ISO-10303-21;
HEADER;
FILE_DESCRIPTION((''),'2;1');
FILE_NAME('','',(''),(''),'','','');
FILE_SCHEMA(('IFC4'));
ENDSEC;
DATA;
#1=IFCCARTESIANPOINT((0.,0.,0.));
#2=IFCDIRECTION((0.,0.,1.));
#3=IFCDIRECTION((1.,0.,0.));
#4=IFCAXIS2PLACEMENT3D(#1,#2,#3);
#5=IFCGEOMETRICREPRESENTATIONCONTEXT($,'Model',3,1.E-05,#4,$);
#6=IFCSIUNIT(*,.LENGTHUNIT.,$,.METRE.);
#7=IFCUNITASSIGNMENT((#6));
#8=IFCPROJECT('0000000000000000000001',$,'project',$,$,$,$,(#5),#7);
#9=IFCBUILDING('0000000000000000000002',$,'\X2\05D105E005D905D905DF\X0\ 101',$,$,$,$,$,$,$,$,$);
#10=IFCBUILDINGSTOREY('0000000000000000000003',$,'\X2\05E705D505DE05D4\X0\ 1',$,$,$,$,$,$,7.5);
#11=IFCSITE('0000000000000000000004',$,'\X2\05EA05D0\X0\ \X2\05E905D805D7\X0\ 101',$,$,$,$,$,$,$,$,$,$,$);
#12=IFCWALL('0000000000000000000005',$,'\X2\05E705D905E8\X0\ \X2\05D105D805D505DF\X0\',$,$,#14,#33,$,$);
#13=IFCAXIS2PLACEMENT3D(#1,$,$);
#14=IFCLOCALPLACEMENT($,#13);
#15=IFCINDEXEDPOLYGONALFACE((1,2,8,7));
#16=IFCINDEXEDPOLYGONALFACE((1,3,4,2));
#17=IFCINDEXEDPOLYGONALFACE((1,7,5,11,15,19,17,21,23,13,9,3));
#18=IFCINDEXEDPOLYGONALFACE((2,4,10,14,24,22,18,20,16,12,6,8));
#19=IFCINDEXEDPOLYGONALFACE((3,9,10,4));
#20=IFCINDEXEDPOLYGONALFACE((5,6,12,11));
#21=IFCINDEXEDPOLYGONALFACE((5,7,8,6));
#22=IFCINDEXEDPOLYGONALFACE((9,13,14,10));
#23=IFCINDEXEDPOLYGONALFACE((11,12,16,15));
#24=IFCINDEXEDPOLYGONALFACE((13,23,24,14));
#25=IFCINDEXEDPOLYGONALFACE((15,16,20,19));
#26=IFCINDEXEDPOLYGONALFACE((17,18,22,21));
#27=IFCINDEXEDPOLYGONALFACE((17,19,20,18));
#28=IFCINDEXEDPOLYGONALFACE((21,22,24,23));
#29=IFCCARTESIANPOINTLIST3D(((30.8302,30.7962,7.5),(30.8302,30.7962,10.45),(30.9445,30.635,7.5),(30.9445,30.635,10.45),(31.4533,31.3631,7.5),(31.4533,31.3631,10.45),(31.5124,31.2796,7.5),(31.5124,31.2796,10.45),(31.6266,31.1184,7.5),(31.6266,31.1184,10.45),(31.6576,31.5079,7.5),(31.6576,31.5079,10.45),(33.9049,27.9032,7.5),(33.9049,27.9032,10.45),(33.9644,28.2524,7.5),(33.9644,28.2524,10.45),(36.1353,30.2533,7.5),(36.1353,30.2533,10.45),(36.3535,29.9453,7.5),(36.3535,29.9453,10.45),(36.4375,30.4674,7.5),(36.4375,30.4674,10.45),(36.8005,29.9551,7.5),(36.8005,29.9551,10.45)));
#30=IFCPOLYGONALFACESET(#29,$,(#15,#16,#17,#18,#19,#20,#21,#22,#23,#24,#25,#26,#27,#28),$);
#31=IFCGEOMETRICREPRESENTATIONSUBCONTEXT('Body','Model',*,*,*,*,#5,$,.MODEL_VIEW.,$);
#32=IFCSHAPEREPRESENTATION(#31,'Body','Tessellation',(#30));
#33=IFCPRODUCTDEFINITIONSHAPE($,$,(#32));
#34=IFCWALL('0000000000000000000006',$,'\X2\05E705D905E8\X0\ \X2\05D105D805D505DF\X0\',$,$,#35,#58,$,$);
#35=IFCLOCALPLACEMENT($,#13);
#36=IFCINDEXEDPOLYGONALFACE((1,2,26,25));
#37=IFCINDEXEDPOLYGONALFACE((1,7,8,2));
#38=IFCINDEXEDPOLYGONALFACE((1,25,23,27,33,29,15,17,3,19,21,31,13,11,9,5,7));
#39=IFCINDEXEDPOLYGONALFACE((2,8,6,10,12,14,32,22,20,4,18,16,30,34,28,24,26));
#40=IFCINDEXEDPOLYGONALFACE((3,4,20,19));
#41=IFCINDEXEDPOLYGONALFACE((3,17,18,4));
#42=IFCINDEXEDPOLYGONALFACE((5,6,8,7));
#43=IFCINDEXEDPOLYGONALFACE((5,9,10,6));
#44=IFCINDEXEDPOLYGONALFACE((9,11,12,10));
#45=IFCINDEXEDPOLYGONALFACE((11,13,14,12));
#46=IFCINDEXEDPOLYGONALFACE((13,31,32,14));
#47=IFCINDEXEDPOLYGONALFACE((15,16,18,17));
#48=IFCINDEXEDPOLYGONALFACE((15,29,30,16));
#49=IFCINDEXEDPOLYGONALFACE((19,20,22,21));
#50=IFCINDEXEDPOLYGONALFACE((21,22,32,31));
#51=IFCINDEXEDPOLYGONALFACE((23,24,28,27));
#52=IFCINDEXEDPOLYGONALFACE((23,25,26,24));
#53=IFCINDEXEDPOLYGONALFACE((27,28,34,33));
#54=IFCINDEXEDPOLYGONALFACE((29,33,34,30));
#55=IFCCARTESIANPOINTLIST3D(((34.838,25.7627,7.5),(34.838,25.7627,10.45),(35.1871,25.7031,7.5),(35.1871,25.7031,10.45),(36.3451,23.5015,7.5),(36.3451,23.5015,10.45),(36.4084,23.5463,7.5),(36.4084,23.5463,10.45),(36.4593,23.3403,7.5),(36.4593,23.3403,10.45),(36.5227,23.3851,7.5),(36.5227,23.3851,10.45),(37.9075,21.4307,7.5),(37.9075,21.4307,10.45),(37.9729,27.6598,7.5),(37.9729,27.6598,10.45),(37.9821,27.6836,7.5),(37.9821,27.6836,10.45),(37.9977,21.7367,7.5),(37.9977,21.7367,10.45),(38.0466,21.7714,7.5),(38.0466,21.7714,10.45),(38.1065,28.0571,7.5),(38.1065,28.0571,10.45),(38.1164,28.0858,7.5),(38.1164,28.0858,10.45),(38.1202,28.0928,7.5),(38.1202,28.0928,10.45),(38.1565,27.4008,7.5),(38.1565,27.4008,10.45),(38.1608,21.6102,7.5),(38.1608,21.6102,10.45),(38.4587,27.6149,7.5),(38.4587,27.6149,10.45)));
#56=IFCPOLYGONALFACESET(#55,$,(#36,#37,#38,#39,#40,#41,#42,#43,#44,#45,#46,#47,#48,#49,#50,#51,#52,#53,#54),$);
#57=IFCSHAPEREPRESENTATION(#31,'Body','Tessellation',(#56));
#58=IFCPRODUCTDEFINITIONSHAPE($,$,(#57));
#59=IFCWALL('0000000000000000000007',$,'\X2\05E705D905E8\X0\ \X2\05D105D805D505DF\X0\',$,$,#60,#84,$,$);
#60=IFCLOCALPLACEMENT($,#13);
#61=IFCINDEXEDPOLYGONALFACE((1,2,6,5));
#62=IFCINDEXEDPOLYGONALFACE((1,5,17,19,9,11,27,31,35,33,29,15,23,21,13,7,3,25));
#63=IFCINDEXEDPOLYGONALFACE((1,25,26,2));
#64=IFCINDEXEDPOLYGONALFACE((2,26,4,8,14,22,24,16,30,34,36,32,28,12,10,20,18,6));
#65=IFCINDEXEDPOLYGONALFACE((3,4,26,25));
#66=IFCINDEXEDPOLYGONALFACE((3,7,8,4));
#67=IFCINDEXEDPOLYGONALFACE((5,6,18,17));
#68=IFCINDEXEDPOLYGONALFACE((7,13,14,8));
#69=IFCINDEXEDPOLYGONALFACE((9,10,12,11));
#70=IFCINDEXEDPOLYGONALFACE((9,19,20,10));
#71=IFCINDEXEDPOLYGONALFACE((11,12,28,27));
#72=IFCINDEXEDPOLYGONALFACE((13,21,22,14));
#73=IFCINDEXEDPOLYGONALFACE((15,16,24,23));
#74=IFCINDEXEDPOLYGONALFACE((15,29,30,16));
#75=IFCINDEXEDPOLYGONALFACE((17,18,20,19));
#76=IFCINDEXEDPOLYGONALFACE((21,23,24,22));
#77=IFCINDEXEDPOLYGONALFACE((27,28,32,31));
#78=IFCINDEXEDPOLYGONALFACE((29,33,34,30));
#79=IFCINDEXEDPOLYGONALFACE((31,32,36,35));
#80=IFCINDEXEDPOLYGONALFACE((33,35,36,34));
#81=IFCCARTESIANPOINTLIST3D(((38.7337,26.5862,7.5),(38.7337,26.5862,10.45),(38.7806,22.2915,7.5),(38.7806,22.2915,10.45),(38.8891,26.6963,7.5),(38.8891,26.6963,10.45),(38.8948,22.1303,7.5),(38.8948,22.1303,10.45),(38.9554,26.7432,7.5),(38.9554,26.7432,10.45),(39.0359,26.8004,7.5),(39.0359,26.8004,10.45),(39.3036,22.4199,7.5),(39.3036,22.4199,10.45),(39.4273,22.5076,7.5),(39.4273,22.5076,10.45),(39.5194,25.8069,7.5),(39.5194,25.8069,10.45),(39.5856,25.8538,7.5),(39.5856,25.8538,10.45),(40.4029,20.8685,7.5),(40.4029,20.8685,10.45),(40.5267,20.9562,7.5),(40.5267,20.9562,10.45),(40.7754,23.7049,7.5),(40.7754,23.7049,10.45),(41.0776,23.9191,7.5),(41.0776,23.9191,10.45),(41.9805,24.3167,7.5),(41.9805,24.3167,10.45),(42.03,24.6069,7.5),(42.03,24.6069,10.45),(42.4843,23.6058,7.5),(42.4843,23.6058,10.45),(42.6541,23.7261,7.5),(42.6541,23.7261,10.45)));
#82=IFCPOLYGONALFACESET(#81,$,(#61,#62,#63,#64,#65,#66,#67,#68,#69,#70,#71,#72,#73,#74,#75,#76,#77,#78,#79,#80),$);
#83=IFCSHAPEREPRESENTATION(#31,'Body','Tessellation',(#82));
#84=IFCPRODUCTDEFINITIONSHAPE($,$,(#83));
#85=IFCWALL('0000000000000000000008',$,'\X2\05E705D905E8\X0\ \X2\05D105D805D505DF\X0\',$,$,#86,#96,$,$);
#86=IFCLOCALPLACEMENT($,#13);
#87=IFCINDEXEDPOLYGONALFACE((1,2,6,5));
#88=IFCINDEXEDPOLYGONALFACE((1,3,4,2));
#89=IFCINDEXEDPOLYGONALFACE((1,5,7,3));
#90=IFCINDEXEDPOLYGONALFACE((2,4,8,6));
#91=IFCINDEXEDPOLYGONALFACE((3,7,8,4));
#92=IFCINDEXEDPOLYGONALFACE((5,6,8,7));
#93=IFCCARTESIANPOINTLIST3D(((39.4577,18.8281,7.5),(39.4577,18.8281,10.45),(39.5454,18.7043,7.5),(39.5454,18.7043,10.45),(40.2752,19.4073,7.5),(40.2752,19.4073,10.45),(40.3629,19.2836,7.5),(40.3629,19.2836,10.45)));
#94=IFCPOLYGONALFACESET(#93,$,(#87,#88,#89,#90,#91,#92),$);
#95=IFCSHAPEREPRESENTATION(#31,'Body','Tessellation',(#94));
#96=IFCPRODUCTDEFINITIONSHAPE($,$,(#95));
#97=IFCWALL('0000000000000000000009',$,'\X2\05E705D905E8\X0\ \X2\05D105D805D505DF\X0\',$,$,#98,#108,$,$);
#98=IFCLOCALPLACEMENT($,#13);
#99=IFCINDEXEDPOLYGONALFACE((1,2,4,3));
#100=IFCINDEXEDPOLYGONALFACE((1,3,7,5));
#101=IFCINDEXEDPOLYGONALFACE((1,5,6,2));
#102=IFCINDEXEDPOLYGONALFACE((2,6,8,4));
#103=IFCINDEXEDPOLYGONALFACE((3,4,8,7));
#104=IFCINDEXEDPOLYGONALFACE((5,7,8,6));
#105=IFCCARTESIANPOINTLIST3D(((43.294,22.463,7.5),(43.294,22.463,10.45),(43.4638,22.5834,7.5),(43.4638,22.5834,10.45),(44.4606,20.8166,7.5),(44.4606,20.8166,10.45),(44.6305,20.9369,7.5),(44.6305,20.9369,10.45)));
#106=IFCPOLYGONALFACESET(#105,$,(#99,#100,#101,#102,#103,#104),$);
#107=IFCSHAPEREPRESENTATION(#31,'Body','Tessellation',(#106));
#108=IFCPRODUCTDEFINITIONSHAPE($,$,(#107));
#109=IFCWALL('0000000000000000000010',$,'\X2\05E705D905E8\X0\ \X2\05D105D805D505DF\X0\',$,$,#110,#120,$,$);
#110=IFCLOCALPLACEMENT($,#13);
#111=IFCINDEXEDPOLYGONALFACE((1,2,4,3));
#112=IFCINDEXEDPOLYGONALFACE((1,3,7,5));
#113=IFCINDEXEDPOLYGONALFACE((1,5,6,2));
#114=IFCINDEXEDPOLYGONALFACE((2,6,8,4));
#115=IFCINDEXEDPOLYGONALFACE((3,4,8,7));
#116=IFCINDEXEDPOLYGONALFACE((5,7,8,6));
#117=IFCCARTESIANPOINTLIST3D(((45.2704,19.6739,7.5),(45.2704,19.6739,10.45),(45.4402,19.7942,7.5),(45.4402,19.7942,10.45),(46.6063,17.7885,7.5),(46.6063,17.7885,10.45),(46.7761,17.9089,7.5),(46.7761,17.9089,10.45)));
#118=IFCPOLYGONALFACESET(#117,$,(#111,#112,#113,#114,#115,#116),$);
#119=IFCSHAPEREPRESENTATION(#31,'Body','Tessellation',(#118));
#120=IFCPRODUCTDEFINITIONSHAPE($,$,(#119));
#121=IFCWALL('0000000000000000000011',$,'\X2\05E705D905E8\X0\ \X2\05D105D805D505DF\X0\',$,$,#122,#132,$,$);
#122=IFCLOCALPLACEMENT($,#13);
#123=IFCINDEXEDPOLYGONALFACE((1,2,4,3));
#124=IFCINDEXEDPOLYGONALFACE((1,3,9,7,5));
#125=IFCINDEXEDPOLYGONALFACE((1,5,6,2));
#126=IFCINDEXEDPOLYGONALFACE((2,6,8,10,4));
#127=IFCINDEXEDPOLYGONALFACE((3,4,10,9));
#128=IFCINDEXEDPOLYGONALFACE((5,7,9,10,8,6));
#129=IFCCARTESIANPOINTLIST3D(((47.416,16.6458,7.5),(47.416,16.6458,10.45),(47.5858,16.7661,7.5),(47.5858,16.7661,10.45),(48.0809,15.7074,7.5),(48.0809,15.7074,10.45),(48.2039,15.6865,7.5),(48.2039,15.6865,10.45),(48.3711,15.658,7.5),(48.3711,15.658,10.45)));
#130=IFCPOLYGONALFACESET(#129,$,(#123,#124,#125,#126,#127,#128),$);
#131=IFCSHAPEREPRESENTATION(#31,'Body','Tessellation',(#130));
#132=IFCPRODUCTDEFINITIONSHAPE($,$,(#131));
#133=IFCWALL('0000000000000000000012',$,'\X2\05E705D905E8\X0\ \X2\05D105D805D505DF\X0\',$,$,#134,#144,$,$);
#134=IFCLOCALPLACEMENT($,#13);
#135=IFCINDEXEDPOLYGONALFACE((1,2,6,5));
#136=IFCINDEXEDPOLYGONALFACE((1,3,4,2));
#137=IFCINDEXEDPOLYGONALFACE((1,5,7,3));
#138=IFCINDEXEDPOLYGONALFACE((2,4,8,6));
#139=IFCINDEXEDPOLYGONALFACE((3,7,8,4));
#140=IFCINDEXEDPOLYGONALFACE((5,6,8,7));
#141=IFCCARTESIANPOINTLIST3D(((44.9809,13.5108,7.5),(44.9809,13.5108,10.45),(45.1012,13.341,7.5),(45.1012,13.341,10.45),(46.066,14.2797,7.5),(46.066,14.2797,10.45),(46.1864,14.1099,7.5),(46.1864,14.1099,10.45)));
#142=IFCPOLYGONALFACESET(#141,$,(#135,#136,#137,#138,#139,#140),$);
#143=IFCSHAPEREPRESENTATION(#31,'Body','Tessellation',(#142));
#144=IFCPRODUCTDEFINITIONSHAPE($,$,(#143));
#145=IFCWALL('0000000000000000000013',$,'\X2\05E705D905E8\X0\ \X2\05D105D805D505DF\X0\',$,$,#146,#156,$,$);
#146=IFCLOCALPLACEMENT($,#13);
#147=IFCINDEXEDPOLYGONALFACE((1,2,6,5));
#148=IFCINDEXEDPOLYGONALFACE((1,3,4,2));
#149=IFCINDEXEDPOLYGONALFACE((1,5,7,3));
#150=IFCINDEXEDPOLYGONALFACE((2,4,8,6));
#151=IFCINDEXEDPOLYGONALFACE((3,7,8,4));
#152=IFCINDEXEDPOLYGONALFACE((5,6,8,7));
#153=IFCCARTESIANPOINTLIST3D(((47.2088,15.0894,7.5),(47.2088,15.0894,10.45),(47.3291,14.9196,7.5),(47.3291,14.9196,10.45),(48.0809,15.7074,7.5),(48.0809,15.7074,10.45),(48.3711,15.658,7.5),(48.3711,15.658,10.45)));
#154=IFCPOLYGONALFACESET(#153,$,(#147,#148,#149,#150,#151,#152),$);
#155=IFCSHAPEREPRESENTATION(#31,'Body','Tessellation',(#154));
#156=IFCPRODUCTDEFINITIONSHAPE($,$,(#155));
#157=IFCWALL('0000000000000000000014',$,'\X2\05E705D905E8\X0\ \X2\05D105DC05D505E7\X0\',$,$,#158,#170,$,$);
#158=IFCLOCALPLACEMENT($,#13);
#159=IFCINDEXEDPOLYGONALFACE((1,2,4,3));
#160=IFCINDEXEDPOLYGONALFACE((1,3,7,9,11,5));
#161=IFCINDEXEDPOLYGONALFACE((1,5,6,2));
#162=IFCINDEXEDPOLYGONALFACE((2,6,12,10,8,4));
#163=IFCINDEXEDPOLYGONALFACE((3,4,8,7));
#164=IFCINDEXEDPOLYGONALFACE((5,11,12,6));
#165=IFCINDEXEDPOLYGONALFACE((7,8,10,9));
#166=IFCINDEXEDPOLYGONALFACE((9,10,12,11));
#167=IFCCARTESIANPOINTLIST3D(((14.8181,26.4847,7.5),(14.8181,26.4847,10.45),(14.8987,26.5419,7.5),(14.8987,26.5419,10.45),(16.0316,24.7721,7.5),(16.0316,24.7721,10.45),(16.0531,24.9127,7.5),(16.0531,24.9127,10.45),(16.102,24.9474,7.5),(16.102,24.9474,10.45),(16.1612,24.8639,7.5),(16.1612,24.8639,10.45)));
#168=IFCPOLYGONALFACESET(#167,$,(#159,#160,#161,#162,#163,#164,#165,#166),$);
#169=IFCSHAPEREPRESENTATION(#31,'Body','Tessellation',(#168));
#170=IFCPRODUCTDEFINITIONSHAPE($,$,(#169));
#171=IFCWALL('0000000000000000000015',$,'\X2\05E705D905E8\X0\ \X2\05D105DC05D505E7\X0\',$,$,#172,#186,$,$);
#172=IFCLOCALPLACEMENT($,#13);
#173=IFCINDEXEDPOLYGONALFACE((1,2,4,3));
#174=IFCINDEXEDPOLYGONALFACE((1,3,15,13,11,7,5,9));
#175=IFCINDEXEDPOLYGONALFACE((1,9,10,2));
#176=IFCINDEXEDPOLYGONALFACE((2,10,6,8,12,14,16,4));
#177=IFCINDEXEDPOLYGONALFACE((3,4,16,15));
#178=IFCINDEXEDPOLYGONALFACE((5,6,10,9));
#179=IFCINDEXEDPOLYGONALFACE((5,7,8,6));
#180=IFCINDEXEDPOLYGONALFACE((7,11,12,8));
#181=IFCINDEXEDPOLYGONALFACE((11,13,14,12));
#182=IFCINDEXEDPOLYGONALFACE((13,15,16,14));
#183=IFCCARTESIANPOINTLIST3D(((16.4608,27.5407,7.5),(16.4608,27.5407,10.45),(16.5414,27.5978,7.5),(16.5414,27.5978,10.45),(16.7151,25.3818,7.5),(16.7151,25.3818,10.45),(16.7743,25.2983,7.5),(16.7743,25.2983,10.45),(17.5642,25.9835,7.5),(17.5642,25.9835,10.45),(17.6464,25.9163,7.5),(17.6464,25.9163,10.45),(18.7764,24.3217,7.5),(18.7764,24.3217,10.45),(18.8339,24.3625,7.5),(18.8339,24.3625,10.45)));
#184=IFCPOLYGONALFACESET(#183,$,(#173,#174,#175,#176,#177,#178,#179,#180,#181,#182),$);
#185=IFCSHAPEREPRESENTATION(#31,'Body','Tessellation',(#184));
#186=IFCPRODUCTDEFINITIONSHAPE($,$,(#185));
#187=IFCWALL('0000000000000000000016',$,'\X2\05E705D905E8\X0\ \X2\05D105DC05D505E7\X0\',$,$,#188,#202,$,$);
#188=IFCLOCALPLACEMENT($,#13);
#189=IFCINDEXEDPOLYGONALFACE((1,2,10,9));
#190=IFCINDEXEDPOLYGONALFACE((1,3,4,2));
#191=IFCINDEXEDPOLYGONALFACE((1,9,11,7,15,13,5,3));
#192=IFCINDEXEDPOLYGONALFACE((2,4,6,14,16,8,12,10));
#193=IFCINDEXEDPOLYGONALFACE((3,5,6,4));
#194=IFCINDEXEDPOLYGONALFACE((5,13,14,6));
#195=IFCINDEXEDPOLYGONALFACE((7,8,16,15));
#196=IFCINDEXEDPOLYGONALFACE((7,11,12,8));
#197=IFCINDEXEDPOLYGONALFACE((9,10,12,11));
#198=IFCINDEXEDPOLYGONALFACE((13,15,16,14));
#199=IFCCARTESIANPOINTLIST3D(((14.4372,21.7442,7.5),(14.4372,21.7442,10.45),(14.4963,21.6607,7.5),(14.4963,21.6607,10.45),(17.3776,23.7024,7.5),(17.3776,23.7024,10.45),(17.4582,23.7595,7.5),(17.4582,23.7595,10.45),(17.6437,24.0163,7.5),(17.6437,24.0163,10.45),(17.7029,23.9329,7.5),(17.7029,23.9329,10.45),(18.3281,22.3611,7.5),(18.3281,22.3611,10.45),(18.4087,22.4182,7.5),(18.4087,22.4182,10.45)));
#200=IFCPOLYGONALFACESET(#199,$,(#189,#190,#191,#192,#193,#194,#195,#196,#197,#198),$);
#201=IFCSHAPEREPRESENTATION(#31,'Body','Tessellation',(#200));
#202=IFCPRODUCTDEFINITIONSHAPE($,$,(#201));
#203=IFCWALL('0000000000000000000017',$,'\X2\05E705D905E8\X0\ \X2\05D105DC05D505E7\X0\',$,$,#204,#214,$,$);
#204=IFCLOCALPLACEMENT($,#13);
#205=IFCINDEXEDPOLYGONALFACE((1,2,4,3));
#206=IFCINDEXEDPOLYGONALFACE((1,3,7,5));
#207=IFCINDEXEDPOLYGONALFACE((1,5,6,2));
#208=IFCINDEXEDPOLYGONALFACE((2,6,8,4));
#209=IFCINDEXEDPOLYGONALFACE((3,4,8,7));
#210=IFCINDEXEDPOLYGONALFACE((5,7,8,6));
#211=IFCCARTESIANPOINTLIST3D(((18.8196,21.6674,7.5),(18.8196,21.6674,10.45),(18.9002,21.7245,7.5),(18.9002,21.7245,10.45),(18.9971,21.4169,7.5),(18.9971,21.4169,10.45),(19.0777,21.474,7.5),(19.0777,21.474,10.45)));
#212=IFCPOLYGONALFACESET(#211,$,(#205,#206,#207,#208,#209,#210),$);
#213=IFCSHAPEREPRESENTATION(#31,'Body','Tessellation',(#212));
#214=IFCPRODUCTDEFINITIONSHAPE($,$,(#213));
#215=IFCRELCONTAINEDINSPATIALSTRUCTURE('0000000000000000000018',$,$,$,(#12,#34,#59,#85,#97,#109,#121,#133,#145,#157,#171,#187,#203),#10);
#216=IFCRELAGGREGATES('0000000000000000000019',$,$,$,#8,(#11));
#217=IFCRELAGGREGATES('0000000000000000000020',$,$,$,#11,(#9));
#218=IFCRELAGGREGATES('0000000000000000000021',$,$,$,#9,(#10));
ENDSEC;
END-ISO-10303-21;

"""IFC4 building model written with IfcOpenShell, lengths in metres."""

from ifc_helpers import new_model, si_unit, frame, origin_with_axes, context, subcontext, project, spatial, polyline, outline, extrude, element, save


model = new_model("IFC4")

# Units and contexts
model_context = context("Model", 3, precision=1e-05, world=origin_with_axes())
body_context = subcontext(model_context, "Body", "Model", "MODEL_VIEW")
ifc_project = project(units=[si_unit("LENGTHUNIT", "METRE")], contexts=[model_context])

# Site, building, storey
site = spatial("IfcSite", under=ifc_project, Name="תא שטח 101")
building = spatial("IfcBuilding", under=site, Name="בניין 101")
storey = spatial("IfcBuildingStorey", under=building, Name="קומה 1", Elevation=7.5)

# Walls
element("IfcWall", 1, inside=storey, Name="קיר בטון", context=body_context, shape_type="SweptSolid", body=[
    extrude(outline(polyline([(31.6266, 31.1184), (33.9049, 27.9032), (36.8005, 29.9551), (36.4375, 30.4674), (36.1353, 30.2533), (36.3535, 29.9453), (33.9644, 28.2524), (31.6576, 31.5079), (31.4533, 31.3631), (31.5124, 31.2796), (30.8302, 30.7962), (30.9445, 30.635), (31.6266, 31.1184)])), frame((0.0, 0.0, 7.5)), (0.0, 0.0, 1.0), 2.95),
])
element("IfcWall", 2, inside=storey, Name="קיר בטון", context=body_context, shape_type="SweptSolid", body=[
    extrude(outline(polyline([(38.1202, 28.0928), (38.1065, 28.0571), (38.1164, 28.0858), (34.838, 25.7627), (36.4084, 23.5463), (36.3451, 23.5015), (36.4593, 23.3403), (36.5227, 23.3851), (37.9075, 21.4307), (38.1608, 21.6102), (38.0466, 21.7714), (37.9977, 21.7367), (35.1871, 25.7031), (37.9821, 27.6836), (37.9729, 27.6598), (38.1565, 27.4008), (38.4587, 27.6149), (38.1202, 28.0928)])), frame((0.0, 0.0, 7.5)), (0.0, 0.0, 1.0), 2.95),
])
element("IfcWall", 3, inside=storey, Name="קיר בטון", context=body_context, shape_type="SweptSolid", body=[
    extrude(outline(polyline([(38.7337, 26.5862), (40.7754, 23.7049), (38.7806, 22.2915), (38.8948, 22.1303), (39.3036, 22.4199), (40.4029, 20.8685), (40.5267, 20.9562), (39.4273, 22.5076), (41.9805, 24.3167), (42.4843, 23.6058), (42.6541, 23.7261), (42.03, 24.6069), (41.0776, 23.9191), (39.0359, 26.8004), (38.9554, 26.7432), (39.5856, 25.8538), (39.5194, 25.8069), (38.8891, 26.6963), (38.7337, 26.5862)])), frame((0.0, 0.0, 7.5)), (0.0, 0.0, 1.0), 2.95),
])
element("IfcWall", 4, inside=storey, Name="קיר בטון", context=body_context, shape_type="SweptSolid", body=[
    extrude(outline(polyline([(40.3629, 19.2836), (40.2752, 19.4073), (39.4577, 18.8281), (39.5454, 18.7043), (40.3629, 19.2836)])), frame((0.0, 0.0, 7.5)), (0.0, 0.0, 1.0), 2.95),
])
element("IfcWall", 5, inside=storey, Name="קיר בטון", context=body_context, shape_type="SweptSolid", body=[
    extrude(outline(polyline([(43.294, 22.463), (44.4606, 20.8166), (44.6305, 20.9369), (43.4638, 22.5834), (43.294, 22.463)])), frame((0.0, 0.0, 7.5)), (0.0, 0.0, 1.0), 2.95),
])
element("IfcWall", 6, inside=storey, Name="קיר בטון", context=body_context, shape_type="SweptSolid", body=[
    extrude(outline(polyline([(45.2704, 19.6739), (46.6063, 17.7885), (46.7761, 17.9089), (45.4402, 19.7942), (45.2704, 19.6739)])), frame((0.0, 0.0, 7.5)), (0.0, 0.0, 1.0), 2.95),
])
element("IfcWall", 7, inside=storey, Name="קיר בטון", context=body_context, shape_type="SweptSolid", body=[
    extrude(outline(polyline([(47.416, 16.6458), (48.0809, 15.7074), (48.2039, 15.6865), (48.3711, 15.658), (47.5858, 16.7661), (47.416, 16.6458)])), frame((0.0, 0.0, 7.5)), (0.0, 0.0, 1.0), 2.95),
])
element("IfcWall", 8, inside=storey, Name="קיר בטון", context=body_context, shape_type="SweptSolid", body=[
    extrude(outline(polyline([(44.9809, 13.5108), (45.1012, 13.341), (46.1864, 14.1099), (46.066, 14.2797), (44.9809, 13.5108)])), frame((0.0, 0.0, 7.5)), (0.0, 0.0, 1.0), 2.95),
])
element("IfcWall", 9, inside=storey, Name="קיר בטון", context=body_context, shape_type="SweptSolid", body=[
    extrude(outline(polyline([(48.0809, 15.7074), (47.2088, 15.0894), (47.3291, 14.9196), (48.3711, 15.658), (48.0809, 15.7074)])), frame((0.0, 0.0, 7.5)), (0.0, 0.0, 1.0), 2.95),
])
element("IfcWall", 10, inside=storey, Name="קיר בלוק", context=body_context, shape_type="SweptSolid", body=[
    extrude(outline(polyline([(14.8181, 26.4847), (16.0316, 24.7721), (16.1612, 24.8639), (16.102, 24.9474), (16.0531, 24.9127), (14.8987, 26.5419), (14.8181, 26.4847)])), frame((0.0, 0.0, 7.5)), (0.0, 0.0, 1.0), 2.95),
])
element("IfcWall", 11, inside=storey, Name="קיר בלוק", context=body_context, shape_type="SweptSolid", body=[
    extrude(outline(polyline([(16.7743, 25.2983), (17.6464, 25.9163), (18.7764, 24.3217), (18.8339, 24.3625), (16.5414, 27.5978), (16.4608, 27.5407), (17.5642, 25.9835), (16.7151, 25.3818), (16.7743, 25.2983)])), frame((0.0, 0.0, 7.5)), (0.0, 0.0, 1.0), 2.95),
])
element("IfcWall", 12, inside=storey, Name="קיר בלוק", context=body_context, shape_type="SweptSolid", body=[
    extrude(outline(polyline([(17.7029, 23.9329), (17.6437, 24.0163), (14.4372, 21.7442), (14.4963, 21.6607), (17.3776, 23.7024), (18.3281, 22.3611), (18.4087, 22.4182), (17.4582, 23.7595), (17.7029, 23.9329)])), frame((0.0, 0.0, 7.5)), (0.0, 0.0, 1.0), 2.95),
])
element("IfcWall", 13, inside=storey, Name="קיר בלוק", context=body_context, shape_type="SweptSolid", body=[
    extrude(outline(polyline([(18.8196, 21.6674), (18.9971, 21.4169), (19.0777, 21.474), (18.9002, 21.7245), (18.8196, 21.6674)])), frame((0.0, 0.0, 7.5)), (0.0, 0.0, 1.0), 2.95),
])

save(model, "model.ifc")
